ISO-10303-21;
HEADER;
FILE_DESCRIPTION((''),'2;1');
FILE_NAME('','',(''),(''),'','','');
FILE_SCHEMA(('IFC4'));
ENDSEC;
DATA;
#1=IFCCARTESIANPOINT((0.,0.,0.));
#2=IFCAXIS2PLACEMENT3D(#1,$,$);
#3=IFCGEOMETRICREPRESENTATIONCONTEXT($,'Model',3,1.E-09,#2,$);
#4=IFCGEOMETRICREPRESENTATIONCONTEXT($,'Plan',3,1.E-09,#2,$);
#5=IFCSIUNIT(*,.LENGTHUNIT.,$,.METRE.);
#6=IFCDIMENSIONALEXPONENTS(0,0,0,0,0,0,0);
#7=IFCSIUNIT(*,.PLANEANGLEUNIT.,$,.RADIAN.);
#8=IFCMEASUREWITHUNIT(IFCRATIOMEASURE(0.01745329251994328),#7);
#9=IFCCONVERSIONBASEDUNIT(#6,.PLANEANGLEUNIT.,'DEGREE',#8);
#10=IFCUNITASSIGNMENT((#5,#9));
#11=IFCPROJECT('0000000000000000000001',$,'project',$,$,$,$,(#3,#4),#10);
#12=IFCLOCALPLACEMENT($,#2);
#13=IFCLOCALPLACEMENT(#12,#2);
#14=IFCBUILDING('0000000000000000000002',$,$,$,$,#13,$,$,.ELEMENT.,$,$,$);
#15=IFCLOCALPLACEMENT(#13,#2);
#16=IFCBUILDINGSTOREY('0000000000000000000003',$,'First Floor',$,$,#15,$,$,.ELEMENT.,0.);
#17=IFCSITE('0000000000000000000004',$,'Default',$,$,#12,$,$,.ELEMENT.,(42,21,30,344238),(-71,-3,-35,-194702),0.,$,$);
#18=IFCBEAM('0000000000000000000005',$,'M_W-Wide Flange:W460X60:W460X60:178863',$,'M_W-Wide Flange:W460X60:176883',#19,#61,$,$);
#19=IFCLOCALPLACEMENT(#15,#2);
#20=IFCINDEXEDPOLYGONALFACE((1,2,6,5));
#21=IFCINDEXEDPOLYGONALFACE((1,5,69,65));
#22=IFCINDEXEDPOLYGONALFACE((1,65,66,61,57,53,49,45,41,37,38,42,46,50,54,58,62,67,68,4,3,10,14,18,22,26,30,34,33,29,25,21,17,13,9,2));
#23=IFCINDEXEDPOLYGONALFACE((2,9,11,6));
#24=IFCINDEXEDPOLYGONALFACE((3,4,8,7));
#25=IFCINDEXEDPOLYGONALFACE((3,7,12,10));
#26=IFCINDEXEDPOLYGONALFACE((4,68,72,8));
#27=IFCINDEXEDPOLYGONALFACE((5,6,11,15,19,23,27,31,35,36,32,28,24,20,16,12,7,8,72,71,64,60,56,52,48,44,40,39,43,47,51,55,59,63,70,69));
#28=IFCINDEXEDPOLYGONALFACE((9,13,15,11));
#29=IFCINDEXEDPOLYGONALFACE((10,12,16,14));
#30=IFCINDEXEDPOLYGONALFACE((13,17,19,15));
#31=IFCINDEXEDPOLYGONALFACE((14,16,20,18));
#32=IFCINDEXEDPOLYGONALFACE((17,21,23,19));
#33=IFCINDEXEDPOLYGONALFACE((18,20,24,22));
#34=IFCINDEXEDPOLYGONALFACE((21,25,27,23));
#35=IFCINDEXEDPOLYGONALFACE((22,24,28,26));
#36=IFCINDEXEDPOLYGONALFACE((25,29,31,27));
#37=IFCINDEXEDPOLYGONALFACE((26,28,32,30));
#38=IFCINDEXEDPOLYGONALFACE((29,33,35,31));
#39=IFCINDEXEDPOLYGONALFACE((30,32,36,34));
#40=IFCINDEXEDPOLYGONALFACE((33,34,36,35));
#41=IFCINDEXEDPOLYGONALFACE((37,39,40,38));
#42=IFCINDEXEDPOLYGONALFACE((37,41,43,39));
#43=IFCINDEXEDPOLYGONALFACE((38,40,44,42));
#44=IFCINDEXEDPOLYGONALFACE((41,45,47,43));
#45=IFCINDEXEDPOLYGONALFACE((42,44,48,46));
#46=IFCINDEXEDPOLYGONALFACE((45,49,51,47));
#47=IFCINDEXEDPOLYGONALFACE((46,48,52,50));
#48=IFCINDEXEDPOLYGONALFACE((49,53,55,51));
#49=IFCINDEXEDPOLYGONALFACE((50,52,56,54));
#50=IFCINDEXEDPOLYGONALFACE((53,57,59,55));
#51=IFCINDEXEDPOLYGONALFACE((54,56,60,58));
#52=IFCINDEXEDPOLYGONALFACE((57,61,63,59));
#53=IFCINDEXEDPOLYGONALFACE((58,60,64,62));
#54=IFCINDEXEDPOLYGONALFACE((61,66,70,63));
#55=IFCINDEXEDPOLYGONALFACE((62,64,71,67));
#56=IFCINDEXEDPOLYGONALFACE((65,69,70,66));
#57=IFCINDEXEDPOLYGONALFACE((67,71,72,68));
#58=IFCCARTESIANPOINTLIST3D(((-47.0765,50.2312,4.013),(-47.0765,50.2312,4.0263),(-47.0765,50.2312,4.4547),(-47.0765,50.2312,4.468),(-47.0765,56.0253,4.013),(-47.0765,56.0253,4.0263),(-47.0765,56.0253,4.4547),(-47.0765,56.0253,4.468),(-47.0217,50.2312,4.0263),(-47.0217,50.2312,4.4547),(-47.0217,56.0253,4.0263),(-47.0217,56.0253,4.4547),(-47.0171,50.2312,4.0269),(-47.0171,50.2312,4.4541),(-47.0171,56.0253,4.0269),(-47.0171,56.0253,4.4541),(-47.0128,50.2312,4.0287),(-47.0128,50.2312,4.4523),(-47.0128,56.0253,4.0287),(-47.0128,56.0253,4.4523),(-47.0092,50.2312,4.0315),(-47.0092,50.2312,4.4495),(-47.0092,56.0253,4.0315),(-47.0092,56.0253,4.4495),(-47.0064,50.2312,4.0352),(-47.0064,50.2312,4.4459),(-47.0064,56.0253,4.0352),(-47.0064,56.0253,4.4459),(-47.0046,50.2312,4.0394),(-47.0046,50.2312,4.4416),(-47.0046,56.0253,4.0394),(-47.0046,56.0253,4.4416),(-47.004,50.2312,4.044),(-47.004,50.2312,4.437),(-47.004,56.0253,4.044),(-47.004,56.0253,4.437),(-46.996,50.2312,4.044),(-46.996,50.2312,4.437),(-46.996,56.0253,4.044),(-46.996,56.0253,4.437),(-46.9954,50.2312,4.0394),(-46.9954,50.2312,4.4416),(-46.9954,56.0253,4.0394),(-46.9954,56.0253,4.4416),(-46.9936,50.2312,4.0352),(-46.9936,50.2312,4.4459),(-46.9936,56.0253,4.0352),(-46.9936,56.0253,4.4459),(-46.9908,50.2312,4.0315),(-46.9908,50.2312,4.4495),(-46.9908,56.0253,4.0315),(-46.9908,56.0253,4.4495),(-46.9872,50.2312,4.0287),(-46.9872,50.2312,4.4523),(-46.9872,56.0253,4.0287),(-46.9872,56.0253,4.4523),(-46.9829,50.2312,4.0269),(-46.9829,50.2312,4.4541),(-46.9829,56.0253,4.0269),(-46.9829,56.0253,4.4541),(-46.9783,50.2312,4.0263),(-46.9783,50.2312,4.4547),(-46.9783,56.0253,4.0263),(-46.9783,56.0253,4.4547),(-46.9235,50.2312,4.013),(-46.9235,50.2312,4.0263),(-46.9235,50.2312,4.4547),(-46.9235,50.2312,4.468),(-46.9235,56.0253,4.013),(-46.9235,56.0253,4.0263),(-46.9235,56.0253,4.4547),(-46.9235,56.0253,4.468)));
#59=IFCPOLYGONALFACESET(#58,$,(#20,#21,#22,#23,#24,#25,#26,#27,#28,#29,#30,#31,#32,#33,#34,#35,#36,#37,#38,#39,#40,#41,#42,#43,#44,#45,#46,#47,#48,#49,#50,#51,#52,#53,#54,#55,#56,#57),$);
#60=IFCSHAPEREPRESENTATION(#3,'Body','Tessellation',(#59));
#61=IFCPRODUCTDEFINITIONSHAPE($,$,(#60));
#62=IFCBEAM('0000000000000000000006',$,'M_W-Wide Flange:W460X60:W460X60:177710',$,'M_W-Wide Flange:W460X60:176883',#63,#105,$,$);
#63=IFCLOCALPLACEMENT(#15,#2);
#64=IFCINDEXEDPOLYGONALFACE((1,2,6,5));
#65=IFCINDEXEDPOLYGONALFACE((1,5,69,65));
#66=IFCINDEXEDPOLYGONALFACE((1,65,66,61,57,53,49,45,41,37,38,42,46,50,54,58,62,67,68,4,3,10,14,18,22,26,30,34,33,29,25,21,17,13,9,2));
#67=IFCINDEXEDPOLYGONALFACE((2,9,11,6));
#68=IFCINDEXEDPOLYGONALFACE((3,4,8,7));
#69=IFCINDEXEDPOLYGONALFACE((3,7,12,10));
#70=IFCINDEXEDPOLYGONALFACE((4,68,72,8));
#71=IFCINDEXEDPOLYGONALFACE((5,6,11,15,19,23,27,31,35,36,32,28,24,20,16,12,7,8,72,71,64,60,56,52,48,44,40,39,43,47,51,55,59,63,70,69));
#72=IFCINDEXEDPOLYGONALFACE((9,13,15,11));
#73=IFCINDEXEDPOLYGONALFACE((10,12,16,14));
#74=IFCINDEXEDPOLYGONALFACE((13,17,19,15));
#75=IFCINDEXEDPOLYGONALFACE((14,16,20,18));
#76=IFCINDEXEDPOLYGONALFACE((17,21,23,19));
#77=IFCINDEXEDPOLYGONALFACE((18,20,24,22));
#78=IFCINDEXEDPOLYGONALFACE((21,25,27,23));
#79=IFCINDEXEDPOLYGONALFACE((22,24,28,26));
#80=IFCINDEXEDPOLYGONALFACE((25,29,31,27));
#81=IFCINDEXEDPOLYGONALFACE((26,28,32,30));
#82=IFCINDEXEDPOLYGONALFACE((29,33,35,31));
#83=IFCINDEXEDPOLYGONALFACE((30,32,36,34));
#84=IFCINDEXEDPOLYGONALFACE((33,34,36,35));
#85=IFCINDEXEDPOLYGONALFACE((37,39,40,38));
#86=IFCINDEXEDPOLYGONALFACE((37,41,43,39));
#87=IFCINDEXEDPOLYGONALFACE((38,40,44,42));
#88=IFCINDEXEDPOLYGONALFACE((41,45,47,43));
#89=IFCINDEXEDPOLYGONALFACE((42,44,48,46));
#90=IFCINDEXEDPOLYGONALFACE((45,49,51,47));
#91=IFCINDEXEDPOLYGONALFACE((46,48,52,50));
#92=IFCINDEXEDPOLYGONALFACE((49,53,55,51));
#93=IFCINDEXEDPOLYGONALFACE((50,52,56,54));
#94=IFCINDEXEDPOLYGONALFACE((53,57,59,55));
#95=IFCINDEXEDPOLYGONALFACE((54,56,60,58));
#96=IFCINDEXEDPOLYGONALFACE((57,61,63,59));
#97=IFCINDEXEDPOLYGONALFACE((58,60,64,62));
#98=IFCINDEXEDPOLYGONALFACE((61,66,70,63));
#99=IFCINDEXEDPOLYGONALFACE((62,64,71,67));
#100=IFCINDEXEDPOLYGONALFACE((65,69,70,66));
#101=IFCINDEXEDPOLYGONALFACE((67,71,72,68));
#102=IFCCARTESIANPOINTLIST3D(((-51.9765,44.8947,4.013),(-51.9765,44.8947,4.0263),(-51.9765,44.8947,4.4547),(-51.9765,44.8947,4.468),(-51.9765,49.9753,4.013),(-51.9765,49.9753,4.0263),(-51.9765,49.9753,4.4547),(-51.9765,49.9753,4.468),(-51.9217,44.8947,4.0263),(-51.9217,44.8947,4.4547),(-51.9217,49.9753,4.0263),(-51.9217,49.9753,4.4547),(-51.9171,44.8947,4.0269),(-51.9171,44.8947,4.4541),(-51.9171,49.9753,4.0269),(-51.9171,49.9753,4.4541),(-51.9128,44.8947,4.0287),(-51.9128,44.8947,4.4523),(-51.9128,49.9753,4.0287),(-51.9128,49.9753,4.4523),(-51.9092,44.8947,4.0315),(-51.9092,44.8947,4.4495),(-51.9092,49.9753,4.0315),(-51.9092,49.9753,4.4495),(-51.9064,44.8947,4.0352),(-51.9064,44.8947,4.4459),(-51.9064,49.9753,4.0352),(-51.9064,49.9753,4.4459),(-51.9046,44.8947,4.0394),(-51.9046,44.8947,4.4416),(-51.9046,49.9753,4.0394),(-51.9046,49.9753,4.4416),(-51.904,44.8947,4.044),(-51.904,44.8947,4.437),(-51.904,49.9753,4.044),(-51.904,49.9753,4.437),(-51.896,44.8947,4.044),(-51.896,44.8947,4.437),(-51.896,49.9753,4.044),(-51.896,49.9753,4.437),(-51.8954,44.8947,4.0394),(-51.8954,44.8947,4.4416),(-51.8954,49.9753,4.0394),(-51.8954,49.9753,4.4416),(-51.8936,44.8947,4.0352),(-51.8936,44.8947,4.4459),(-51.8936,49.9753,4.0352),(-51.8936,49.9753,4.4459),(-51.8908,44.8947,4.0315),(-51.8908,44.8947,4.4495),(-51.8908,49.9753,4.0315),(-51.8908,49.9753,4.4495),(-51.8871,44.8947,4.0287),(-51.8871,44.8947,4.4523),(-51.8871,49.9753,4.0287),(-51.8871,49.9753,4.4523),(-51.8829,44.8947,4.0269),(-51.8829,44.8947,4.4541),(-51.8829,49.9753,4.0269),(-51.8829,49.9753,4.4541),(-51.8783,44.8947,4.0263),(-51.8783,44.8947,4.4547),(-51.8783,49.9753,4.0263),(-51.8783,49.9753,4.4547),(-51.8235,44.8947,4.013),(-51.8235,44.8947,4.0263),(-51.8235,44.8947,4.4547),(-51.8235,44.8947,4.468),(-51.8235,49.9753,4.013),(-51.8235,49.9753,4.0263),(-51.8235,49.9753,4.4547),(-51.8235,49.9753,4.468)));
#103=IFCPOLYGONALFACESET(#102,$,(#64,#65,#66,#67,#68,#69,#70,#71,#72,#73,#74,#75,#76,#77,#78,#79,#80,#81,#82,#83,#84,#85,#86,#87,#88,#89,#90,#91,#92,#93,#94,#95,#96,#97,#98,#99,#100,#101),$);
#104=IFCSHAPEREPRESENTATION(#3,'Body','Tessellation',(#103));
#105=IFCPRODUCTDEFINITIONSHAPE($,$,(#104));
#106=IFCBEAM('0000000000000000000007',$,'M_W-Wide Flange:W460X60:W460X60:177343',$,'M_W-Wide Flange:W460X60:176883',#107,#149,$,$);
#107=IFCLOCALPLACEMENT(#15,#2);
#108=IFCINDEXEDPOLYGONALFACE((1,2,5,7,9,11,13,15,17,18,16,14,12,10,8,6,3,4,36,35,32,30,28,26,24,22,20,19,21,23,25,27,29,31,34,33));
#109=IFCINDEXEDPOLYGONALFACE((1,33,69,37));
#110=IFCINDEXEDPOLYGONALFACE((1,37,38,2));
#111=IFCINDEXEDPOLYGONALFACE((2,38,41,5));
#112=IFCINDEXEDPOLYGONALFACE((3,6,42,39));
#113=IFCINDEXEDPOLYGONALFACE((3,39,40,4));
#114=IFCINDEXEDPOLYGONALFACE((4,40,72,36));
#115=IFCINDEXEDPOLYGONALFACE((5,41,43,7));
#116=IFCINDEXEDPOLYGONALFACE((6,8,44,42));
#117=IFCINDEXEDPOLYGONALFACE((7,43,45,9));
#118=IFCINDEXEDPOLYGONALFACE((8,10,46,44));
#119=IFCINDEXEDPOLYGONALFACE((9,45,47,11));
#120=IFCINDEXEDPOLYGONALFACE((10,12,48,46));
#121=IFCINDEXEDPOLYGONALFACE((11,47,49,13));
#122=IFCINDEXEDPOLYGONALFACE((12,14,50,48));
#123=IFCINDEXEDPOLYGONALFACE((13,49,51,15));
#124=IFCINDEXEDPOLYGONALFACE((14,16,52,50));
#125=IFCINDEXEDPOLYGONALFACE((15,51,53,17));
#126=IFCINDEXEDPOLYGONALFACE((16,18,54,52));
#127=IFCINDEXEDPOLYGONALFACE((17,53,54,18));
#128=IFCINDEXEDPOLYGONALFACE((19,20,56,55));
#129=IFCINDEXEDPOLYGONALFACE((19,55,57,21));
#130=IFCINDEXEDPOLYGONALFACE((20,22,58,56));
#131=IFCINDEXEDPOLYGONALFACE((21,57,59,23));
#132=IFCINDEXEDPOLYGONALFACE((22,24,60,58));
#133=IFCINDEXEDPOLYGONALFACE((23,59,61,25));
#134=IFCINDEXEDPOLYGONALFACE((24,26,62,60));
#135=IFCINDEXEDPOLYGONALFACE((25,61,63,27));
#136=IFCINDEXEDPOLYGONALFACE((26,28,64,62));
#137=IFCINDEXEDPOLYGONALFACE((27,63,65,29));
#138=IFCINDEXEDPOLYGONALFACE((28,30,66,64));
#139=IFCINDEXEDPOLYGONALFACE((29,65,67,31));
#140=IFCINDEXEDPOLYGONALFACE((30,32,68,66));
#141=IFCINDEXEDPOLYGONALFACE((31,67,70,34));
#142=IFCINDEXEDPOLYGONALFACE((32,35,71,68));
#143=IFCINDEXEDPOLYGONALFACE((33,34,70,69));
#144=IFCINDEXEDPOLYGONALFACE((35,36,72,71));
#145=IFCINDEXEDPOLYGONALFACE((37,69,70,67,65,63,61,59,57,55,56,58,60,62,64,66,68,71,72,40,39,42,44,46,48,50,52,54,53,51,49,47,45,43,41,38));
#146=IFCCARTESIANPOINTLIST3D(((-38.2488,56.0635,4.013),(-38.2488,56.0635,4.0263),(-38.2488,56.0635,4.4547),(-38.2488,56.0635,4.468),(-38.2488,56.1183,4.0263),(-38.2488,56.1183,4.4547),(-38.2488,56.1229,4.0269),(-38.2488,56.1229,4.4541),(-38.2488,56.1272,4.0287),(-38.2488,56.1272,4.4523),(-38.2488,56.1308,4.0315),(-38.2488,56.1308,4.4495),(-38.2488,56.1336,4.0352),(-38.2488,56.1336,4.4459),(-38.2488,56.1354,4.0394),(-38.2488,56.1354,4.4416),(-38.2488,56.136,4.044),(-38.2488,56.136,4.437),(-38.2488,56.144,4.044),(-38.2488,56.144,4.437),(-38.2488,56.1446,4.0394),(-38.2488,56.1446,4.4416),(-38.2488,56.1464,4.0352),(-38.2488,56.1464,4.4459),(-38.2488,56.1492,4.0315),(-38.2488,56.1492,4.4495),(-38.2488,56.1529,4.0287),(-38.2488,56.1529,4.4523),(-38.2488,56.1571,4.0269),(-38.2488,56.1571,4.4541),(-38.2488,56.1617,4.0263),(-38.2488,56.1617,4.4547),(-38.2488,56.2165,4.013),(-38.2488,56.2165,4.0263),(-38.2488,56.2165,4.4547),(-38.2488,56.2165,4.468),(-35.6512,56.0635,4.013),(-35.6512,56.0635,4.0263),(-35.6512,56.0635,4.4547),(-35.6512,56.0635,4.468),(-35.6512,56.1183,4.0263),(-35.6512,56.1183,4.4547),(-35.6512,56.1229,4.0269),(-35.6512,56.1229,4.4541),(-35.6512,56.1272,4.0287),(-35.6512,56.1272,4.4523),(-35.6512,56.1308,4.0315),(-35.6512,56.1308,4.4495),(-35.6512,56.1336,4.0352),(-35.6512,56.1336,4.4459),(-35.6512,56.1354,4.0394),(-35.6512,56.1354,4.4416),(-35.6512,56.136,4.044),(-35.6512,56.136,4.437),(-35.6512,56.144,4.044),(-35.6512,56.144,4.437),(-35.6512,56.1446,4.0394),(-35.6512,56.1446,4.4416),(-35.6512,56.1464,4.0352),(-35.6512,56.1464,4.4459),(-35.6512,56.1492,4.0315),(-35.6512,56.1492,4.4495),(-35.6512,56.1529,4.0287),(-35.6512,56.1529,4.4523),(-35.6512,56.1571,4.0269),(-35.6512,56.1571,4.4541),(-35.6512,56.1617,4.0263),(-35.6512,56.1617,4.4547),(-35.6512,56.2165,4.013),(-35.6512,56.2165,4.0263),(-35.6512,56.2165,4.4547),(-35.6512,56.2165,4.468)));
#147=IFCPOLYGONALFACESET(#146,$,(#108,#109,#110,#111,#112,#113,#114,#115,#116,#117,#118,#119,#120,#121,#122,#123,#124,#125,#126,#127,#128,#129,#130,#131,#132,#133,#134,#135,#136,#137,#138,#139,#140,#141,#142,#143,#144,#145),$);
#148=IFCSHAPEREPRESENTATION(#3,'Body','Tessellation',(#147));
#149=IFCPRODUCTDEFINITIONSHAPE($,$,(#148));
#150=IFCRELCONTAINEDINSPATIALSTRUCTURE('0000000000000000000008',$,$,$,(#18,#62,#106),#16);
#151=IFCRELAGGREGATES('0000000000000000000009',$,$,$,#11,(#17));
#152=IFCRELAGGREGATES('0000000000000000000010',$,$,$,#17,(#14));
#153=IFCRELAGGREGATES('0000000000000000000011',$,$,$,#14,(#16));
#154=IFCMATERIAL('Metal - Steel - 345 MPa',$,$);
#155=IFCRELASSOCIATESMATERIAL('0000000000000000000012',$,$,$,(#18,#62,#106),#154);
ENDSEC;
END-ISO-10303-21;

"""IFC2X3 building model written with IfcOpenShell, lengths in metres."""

from ifc_helpers import new_model, entity, si_unit, converted_unit, frame, frame_2d, origin, place, context, project, spatial, polyline, circle_curve, parameter, trimmed, segment, composite_curve, outline, extrude, material, element, save


model = new_model("IFC2X3")

# Units and contexts
model_context = context("Model", 3, precision=1e-09, world=origin())
plan_context = context("Plan", 3, precision=1e-09, world=origin())
ifc_project = project(units=[si_unit("LENGTHUNIT", "METRE"), converted_unit("PLANEANGLEUNIT", "DEGREE", entity("IfcRatioMeasure", 0.01745329251994328), si_unit("PLANEANGLEUNIT", "RADIAN"), dimensions=[0, 0, 0, 0, 0, 0, 0])], contexts=[model_context, plan_context])

# Site, building, storey
site_placement = place(None, origin())
site = spatial("IfcSite", under=ifc_project, at=site_placement, Name="Default", CompositionType="ELEMENT", RefLatitude=(42, 21, 30, 344238), RefLongitude=(-71, -3, -35, -194702), RefElevation=0.0)
building_placement = place(site_placement, origin())
building = spatial("IfcBuilding", under=site, at=building_placement, CompositionType="ELEMENT")
storey_placement = place(building_placement, origin())
storey = spatial("IfcBuildingStorey", under=building, at=storey_placement, Name="First Floor", CompositionType="ELEMENT", Elevation=0.0)

# Beams
ifc_material = material(Name="Metal - Steel - 345 MPa")
beam_1_placement = place(storey_placement, frame((-47.0, 50.0877, 4.468)))
element("IfcBeam", 1, at=beam_1_placement, inside=storey, material=ifc_material, Name="M_W-Wide Flange:W460X60:W460X60:178863", ObjectType="M_W-Wide Flange:W460X60:176883", context=model_context, shape_type="SweptSolid", body=[
    extrude(outline(composite_curve([segment(polyline([(-0.0765, -0.2142), (-0.0765, -0.2275)]), True, "CONTINUOUS"), segment(polyline([(-0.0765, -0.2275), (0.0765, -0.2275)]), True, "CONTINUOUS"), segment(polyline([(0.0765, -0.2275), (0.0765, -0.2142)]), True, "CONTINUOUS"), segment(polyline([(0.0765, -0.2142), (0.0217, -0.2142)]), True, "CONTINUOUS"), segment(trimmed(circle_curve(frame_2d((0.0217, -0.1965), x_axis=(1.0, 0.0)), 0.0177), [parameter(180.0)], [parameter(270.0)], True, "PARAMETER"), False, "CONTINUOUS"), segment(polyline([(0.004, -0.1965), (0.004, 0.1965)]), True, "CONTINUOUS"), segment(trimmed(circle_curve(frame_2d((0.0217, 0.1965), x_axis=(1.0, 0.0)), 0.0177), [parameter(90.0)], [parameter(180.0)], True, "PARAMETER"), False, "CONTINUOUS"), segment(polyline([(0.0217, 0.2142), (0.0765, 0.2142)]), True, "CONTINUOUS"), segment(polyline([(0.0765, 0.2142), (0.0765, 0.2275)]), True, "CONTINUOUS"), segment(polyline([(0.0765, 0.2275), (-0.0765, 0.2275)]), True, "CONTINUOUS"), segment(polyline([(-0.0765, 0.2275), (-0.0765, 0.2142)]), True, "CONTINUOUS"), segment(polyline([(-0.0765, 0.2142), (-0.0217, 0.2142)]), True, "CONTINUOUS"), segment(trimmed(circle_curve(frame_2d((-0.0217, 0.1965), x_axis=(1.0, 0.0)), 0.0177), [parameter(360.0)], [parameter(90.0)], True, "PARAMETER"), False, "CONTINUOUS"), segment(polyline([(-0.004, 0.1965), (-0.004, -0.1965)]), True, "CONTINUOUS"), segment(trimmed(circle_curve(frame_2d((-0.0217, -0.1965), x_axis=(1.0, 0.0)), 0.0177), [parameter(270.0)], [parameter(0.0)], True, "PARAMETER"), False, "CONTINUOUS"), segment(polyline([(-0.0217, -0.2142), (-0.0765, -0.2142)]), True, "CONTINUOUS")], self_intersect=False)), frame((0.0, 0.1435, -0.2275), z_axis=(0.0, -1.0, 0.0), x_axis=(1.0, 0.0, 0.0)), (0.0, 0.0, -1.0), 5.7941),
])
beam_2_placement = place(storey_placement, frame((-51.9, 50.0926, 4.468), z_axis=(0.0, 0.0, 1.0), x_axis=(-1.0, 0.0, 0.0)))
element("IfcBeam", 2, at=beam_2_placement, inside=storey, material=ifc_material, Name="M_W-Wide Flange:W460X60:W460X60:177710", ObjectType="M_W-Wide Flange:W460X60:176883", context=model_context, shape_type="SweptSolid", body=[
    extrude(outline(composite_curve([segment(polyline([(0.2142, -0.0765), (0.2275, -0.0765)]), True, "CONTINUOUS"), segment(polyline([(0.2275, -0.0765), (0.2275, 0.0765)]), True, "CONTINUOUS"), segment(polyline([(0.2275, 0.0765), (0.2142, 0.0765)]), True, "CONTINUOUS"), segment(polyline([(0.2142, 0.0765), (0.2142, 0.0217)]), True, "CONTINUOUS"), segment(trimmed(circle_curve(frame_2d((0.1965, 0.0217), x_axis=(1.0, 0.0)), 0.0177), [parameter(270.0)], [parameter(360.0)], True, "PARAMETER"), False, "CONTINUOUS"), segment(polyline([(0.1965, 0.004), (-0.1965, 0.004)]), True, "CONTINUOUS"), segment(trimmed(circle_curve(frame_2d((-0.1965, 0.0217), x_axis=(0.0, -1.0)), 0.0177), [parameter(270.0)], [parameter(360.0)], True, "PARAMETER"), False, "CONTINUOUS"), segment(polyline([(-0.2142, 0.0217), (-0.2142, 0.0765)]), True, "CONTINUOUS"), segment(polyline([(-0.2142, 0.0765), (-0.2275, 0.0765)]), True, "CONTINUOUS"), segment(polyline([(-0.2275, 0.0765), (-0.2275, -0.0765)]), True, "CONTINUOUS"), segment(polyline([(-0.2275, -0.0765), (-0.2142, -0.0765)]), True, "CONTINUOUS"), segment(polyline([(-0.2142, -0.0765), (-0.2142, -0.0217)]), True, "CONTINUOUS"), segment(trimmed(circle_curve(frame_2d((-0.1965, -0.0217), x_axis=(-1.0, 0.0)), 0.0177), [parameter(270.0)], [parameter(360.0)], True, "PARAMETER"), False, "CONTINUOUS"), segment(polyline([(-0.1965, -0.004), (0.1965, -0.004)]), True, "CONTINUOUS"), segment(trimmed(circle_curve(frame_2d((0.1965, -0.0217), x_axis=(0.0, 1.0)), 0.0177), [parameter(270.0)], [parameter(0.0)], True, "PARAMETER"), False, "CONTINUOUS"), segment(polyline([(0.2142, -0.0217), (0.2142, -0.0765)]), True, "CONTINUOUS")], self_intersect=False)), frame((0.0, 5.1979, -0.2275), z_axis=(0.0, -1.0, 0.0), x_axis=(0.0, 0.0, -1.0)), (0.0, 0.0, 1.0), 5.0806),
])
beam_3_placement = place(storey_placement, frame((-38.3852, 56.14, 4.468), z_axis=(0.0, 0.0, 1.0), x_axis=(0.0, -1.0, 0.0)))
element("IfcBeam", 3, at=beam_3_placement, inside=storey, material=ifc_material, Name="M_W-Wide Flange:W460X60:W460X60:177343", ObjectType="M_W-Wide Flange:W460X60:176883", context=model_context, shape_type="SweptSolid", body=[
    extrude(outline(composite_curve([segment(polyline([(-0.0765, -0.2142), (-0.0765, -0.2275)]), True, "CONTINUOUS"), segment(polyline([(-0.0765, -0.2275), (0.0765, -0.2275)]), True, "CONTINUOUS"), segment(polyline([(0.0765, -0.2275), (0.0765, -0.2142)]), True, "CONTINUOUS"), segment(polyline([(0.0765, -0.2142), (0.0217, -0.2142)]), True, "CONTINUOUS"), segment(trimmed(circle_curve(frame_2d((0.0217, -0.1965), x_axis=(0.0, -1.0)), 0.0177), [parameter(270.0)], [parameter(360.0)], True, "PARAMETER"), False, "CONTINUOUS"), segment(polyline([(0.004, -0.1965), (0.004, 0.1965)]), True, "CONTINUOUS"), segment(trimmed(circle_curve(frame_2d((0.0217, 0.1965), x_axis=(-1.0, 0.0)), 0.0177), [parameter(270.0)], [parameter(360.0)], True, "PARAMETER"), False, "CONTINUOUS"), segment(polyline([(0.0217, 0.2142), (0.0765, 0.2142)]), True, "CONTINUOUS"), segment(polyline([(0.0765, 0.2142), (0.0765, 0.2275)]), True, "CONTINUOUS"), segment(polyline([(0.0765, 0.2275), (-0.0765, 0.2275)]), True, "CONTINUOUS"), segment(polyline([(-0.0765, 0.2275), (-0.0765, 0.2142)]), True, "CONTINUOUS"), segment(polyline([(-0.0765, 0.2142), (-0.0217, 0.2142)]), True, "CONTINUOUS"), segment(trimmed(circle_curve(frame_2d((-0.0217, 0.1965), x_axis=(0.0, 1.0)), 0.0177), [parameter(270.0)], [parameter(360.0)], True, "PARAMETER"), False, "CONTINUOUS"), segment(polyline([(-0.004, 0.1965), (-0.004, -0.1965)]), True, "CONTINUOUS"), segment(trimmed(circle_curve(frame_2d((-0.0217, -0.1965), x_axis=(1.0, 0.0)), 0.0177), [parameter(270.0)], [parameter(0.0)], True, "PARAMETER"), False, "CONTINUOUS"), segment(polyline([(-0.0217, -0.2142), (-0.0765, -0.2142)]), True, "CONTINUOUS")], self_intersect=False)), frame((0.0, 0.1364, -0.2275), z_axis=(0.0, -1.0, 0.0), x_axis=(1.0, 0.0, 0.0)), (0.0, 0.0, -1.0), 2.5976),
])

save(model, "model.ifc")
